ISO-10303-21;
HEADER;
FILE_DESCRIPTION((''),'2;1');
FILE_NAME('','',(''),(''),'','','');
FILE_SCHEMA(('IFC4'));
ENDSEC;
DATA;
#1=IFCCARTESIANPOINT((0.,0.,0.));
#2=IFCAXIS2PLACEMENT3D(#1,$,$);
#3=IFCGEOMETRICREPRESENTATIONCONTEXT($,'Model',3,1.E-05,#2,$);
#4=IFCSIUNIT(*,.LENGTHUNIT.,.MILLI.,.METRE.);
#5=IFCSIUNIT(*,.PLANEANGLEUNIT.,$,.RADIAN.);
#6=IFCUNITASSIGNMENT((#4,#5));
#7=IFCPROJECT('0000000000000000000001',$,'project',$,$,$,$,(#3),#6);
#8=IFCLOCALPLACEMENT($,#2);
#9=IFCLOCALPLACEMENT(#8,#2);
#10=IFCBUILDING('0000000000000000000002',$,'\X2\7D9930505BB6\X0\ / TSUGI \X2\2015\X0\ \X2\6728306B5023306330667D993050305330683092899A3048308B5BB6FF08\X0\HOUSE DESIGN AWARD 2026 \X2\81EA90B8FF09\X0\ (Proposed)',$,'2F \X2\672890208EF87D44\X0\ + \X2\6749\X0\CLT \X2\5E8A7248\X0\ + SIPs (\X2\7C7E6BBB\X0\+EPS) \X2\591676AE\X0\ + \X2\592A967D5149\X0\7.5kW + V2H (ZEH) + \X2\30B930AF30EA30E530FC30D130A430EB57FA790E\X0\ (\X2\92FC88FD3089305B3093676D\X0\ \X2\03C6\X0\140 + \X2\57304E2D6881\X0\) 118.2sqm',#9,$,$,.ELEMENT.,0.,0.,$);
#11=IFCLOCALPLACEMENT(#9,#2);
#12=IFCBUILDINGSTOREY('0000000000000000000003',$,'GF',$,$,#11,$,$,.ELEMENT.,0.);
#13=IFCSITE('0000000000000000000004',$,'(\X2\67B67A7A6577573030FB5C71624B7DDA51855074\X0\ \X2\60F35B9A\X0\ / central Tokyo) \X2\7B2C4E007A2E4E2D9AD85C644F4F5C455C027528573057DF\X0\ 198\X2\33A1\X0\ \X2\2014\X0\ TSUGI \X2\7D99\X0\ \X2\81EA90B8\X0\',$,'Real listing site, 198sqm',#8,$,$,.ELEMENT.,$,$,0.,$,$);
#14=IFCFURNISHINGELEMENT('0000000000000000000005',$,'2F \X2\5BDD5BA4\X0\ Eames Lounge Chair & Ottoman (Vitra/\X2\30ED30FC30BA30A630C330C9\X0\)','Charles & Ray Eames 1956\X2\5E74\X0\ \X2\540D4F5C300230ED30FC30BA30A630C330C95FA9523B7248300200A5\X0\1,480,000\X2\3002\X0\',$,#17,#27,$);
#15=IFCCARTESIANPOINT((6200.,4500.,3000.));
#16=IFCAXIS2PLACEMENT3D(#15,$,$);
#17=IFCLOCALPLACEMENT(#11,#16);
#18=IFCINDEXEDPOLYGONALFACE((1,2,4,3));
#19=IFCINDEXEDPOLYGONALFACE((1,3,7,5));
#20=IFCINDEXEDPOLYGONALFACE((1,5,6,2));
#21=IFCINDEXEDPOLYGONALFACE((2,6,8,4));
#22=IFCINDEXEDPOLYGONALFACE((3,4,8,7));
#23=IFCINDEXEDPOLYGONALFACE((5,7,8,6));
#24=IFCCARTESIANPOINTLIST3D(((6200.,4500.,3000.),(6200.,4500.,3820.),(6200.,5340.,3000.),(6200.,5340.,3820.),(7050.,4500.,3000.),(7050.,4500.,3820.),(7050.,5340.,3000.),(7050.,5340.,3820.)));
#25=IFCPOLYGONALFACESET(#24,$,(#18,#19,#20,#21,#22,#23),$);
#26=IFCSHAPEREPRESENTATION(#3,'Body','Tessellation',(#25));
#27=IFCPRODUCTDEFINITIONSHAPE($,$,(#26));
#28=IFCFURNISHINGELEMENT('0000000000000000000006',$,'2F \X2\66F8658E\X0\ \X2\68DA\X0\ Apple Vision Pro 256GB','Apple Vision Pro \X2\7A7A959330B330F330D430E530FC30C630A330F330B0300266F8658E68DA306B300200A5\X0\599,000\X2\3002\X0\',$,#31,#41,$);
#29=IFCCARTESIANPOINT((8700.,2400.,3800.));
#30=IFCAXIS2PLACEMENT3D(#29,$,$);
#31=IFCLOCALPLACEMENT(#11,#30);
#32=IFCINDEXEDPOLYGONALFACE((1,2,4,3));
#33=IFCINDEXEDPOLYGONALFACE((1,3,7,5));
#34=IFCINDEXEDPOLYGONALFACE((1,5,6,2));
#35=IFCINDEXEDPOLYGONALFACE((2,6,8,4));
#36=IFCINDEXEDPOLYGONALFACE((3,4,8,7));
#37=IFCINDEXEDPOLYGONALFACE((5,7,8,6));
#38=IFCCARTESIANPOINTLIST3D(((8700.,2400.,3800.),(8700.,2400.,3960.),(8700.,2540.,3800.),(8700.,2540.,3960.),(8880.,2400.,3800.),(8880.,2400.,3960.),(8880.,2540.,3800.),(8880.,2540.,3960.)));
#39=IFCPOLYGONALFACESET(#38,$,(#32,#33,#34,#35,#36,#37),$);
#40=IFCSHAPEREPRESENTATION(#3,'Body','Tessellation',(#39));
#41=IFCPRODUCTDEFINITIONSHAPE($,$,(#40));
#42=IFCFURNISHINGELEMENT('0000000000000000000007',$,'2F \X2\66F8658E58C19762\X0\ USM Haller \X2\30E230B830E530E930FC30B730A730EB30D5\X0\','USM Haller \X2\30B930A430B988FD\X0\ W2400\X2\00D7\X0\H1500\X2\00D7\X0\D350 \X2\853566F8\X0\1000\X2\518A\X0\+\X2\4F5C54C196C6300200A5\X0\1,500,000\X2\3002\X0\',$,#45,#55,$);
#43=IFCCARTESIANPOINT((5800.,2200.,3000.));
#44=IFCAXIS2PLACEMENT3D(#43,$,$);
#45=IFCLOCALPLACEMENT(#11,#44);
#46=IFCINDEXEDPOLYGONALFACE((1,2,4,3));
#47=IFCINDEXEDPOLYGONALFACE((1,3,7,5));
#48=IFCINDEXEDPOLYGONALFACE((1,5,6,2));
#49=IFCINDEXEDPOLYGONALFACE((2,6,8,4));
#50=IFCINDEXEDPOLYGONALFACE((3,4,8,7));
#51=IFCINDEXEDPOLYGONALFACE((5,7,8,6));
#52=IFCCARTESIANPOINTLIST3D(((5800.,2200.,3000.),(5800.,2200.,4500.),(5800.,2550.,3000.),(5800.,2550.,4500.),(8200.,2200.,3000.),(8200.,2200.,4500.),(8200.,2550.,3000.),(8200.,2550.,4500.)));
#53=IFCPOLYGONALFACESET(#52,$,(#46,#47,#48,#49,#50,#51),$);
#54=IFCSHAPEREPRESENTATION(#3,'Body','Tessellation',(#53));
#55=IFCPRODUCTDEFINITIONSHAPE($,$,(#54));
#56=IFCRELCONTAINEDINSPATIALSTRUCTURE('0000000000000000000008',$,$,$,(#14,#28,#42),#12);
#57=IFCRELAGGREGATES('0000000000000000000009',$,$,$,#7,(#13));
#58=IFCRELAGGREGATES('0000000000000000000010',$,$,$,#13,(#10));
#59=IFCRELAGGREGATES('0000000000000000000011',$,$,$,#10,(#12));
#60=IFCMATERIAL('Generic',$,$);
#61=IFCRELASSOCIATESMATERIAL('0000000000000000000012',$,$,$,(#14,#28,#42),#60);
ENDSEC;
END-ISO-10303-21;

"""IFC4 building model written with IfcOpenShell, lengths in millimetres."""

from ifc_helpers import new_model, si_unit, frame, frame_2d, origin, place, context, project, spatial, rectangle, extrude, material, element, save


model = new_model("IFC4")

# Units and contexts
model_context = context("Model", 3, precision=1e-05, world=origin())
ifc_project = project(units=[si_unit("LENGTHUNIT", "METRE", prefix="MILLI"), si_unit("PLANEANGLEUNIT", "RADIAN")], contexts=[model_context])

# Site, building, storey
site_placement = place(None, origin())
site = spatial("IfcSite", under=ifc_project, at=site_placement, Name="(架空敷地・山手線内側 想定 / central Tokyo) 第一種中高層住居専用地域 198㎡ — TSUGI 継 自邸", ObjectType="Real listing site, 198sqm", CompositionType="ELEMENT", RefElevation=0.0)
building_placement = place(site_placement, origin())
building = spatial("IfcBuilding", under=site, at=building_placement, Name="継ぐ家 / TSUGI ― 木に倣って継ぐことを覚える家（HOUSE DESIGN AWARD 2026 自邸） (Proposed)", ObjectType="2F 木造軸組 + 杉CLT 床版 + SIPs (籾殻+EPS) 外皮 + 太陽光7.5kW + V2H (ZEH) + スクリューパイル基礎 (鋼製らせん杭 φ140 + 地中梁) 118.2sqm", CompositionType="ELEMENT", ElevationOfRefHeight=0.0, ElevationOfTerrain=0.0)
storey_placement = place(building_placement, origin())
storey = spatial("IfcBuildingStorey", under=building, at=storey_placement, Name="GF", CompositionType="ELEMENT", Elevation=0.0)

# Shared definitions
ifc_material_1 = material(Name="Generic")

# Furnishing elements
furnishing_1_placement = place(storey_placement, frame((6200.0, 4500.0, 3000.0)))
element("IfcFurnishingElement", 1, at=furnishing_1_placement, inside=storey, material=ifc_material_1, Name="2F 寝室 Eames Lounge Chair & Ottoman (Vitra/ローズウッド)", Description="Charles & Ray Eames 1956年 名作。ローズウッド復刻版。¥1,480,000。", context=model_context, shape_type="SweptSolid", body=[
    extrude(rectangle(XDim=850.0, YDim=840.0, at=frame_2d((425.0, 420.0))), frame((6200.0, 4500.0, 3000.0)), (0.0, 0.0, 1.0), 820.0),
])
furnishing_2_placement = place(storey_placement, frame((8700.0, 2400.0, 3800.0)))
element("IfcFurnishingElement", 2, at=furnishing_2_placement, inside=storey, material=ifc_material_1, Name="2F 書斎 棚 Apple Vision Pro 256GB", Description="Apple Vision Pro 空間コンピューティング。書斎棚に。¥599,000。", context=model_context, shape_type="SweptSolid", body=[
    extrude(rectangle(XDim=180.0, YDim=140.0, at=frame_2d((90.0, 70.0))), frame((8700.0, 2400.0, 3800.0)), (0.0, 0.0, 1.0), 160.0),
])
furnishing_3_placement = place(storey_placement, frame((5800.0, 2200.0, 3000.0)))
element("IfcFurnishingElement", 3, at=furnishing_3_placement, inside=storey, material=ifc_material_1, Name="2F 書斎壁面 USM Haller モジュラーシェルフ", Description="USM Haller スイス製 W2400×H1500×D350 蔵書1000冊+作品集。¥1,500,000。", context=model_context, shape_type="SweptSolid", body=[
    extrude(rectangle(XDim=2400.0, YDim=350.0, at=frame_2d((1200.0, 175.0))), frame((5800.0, 2200.0, 3000.0)), (0.0, 0.0, 1.0), 1500.0),
])

save(model, "model.ifc")
